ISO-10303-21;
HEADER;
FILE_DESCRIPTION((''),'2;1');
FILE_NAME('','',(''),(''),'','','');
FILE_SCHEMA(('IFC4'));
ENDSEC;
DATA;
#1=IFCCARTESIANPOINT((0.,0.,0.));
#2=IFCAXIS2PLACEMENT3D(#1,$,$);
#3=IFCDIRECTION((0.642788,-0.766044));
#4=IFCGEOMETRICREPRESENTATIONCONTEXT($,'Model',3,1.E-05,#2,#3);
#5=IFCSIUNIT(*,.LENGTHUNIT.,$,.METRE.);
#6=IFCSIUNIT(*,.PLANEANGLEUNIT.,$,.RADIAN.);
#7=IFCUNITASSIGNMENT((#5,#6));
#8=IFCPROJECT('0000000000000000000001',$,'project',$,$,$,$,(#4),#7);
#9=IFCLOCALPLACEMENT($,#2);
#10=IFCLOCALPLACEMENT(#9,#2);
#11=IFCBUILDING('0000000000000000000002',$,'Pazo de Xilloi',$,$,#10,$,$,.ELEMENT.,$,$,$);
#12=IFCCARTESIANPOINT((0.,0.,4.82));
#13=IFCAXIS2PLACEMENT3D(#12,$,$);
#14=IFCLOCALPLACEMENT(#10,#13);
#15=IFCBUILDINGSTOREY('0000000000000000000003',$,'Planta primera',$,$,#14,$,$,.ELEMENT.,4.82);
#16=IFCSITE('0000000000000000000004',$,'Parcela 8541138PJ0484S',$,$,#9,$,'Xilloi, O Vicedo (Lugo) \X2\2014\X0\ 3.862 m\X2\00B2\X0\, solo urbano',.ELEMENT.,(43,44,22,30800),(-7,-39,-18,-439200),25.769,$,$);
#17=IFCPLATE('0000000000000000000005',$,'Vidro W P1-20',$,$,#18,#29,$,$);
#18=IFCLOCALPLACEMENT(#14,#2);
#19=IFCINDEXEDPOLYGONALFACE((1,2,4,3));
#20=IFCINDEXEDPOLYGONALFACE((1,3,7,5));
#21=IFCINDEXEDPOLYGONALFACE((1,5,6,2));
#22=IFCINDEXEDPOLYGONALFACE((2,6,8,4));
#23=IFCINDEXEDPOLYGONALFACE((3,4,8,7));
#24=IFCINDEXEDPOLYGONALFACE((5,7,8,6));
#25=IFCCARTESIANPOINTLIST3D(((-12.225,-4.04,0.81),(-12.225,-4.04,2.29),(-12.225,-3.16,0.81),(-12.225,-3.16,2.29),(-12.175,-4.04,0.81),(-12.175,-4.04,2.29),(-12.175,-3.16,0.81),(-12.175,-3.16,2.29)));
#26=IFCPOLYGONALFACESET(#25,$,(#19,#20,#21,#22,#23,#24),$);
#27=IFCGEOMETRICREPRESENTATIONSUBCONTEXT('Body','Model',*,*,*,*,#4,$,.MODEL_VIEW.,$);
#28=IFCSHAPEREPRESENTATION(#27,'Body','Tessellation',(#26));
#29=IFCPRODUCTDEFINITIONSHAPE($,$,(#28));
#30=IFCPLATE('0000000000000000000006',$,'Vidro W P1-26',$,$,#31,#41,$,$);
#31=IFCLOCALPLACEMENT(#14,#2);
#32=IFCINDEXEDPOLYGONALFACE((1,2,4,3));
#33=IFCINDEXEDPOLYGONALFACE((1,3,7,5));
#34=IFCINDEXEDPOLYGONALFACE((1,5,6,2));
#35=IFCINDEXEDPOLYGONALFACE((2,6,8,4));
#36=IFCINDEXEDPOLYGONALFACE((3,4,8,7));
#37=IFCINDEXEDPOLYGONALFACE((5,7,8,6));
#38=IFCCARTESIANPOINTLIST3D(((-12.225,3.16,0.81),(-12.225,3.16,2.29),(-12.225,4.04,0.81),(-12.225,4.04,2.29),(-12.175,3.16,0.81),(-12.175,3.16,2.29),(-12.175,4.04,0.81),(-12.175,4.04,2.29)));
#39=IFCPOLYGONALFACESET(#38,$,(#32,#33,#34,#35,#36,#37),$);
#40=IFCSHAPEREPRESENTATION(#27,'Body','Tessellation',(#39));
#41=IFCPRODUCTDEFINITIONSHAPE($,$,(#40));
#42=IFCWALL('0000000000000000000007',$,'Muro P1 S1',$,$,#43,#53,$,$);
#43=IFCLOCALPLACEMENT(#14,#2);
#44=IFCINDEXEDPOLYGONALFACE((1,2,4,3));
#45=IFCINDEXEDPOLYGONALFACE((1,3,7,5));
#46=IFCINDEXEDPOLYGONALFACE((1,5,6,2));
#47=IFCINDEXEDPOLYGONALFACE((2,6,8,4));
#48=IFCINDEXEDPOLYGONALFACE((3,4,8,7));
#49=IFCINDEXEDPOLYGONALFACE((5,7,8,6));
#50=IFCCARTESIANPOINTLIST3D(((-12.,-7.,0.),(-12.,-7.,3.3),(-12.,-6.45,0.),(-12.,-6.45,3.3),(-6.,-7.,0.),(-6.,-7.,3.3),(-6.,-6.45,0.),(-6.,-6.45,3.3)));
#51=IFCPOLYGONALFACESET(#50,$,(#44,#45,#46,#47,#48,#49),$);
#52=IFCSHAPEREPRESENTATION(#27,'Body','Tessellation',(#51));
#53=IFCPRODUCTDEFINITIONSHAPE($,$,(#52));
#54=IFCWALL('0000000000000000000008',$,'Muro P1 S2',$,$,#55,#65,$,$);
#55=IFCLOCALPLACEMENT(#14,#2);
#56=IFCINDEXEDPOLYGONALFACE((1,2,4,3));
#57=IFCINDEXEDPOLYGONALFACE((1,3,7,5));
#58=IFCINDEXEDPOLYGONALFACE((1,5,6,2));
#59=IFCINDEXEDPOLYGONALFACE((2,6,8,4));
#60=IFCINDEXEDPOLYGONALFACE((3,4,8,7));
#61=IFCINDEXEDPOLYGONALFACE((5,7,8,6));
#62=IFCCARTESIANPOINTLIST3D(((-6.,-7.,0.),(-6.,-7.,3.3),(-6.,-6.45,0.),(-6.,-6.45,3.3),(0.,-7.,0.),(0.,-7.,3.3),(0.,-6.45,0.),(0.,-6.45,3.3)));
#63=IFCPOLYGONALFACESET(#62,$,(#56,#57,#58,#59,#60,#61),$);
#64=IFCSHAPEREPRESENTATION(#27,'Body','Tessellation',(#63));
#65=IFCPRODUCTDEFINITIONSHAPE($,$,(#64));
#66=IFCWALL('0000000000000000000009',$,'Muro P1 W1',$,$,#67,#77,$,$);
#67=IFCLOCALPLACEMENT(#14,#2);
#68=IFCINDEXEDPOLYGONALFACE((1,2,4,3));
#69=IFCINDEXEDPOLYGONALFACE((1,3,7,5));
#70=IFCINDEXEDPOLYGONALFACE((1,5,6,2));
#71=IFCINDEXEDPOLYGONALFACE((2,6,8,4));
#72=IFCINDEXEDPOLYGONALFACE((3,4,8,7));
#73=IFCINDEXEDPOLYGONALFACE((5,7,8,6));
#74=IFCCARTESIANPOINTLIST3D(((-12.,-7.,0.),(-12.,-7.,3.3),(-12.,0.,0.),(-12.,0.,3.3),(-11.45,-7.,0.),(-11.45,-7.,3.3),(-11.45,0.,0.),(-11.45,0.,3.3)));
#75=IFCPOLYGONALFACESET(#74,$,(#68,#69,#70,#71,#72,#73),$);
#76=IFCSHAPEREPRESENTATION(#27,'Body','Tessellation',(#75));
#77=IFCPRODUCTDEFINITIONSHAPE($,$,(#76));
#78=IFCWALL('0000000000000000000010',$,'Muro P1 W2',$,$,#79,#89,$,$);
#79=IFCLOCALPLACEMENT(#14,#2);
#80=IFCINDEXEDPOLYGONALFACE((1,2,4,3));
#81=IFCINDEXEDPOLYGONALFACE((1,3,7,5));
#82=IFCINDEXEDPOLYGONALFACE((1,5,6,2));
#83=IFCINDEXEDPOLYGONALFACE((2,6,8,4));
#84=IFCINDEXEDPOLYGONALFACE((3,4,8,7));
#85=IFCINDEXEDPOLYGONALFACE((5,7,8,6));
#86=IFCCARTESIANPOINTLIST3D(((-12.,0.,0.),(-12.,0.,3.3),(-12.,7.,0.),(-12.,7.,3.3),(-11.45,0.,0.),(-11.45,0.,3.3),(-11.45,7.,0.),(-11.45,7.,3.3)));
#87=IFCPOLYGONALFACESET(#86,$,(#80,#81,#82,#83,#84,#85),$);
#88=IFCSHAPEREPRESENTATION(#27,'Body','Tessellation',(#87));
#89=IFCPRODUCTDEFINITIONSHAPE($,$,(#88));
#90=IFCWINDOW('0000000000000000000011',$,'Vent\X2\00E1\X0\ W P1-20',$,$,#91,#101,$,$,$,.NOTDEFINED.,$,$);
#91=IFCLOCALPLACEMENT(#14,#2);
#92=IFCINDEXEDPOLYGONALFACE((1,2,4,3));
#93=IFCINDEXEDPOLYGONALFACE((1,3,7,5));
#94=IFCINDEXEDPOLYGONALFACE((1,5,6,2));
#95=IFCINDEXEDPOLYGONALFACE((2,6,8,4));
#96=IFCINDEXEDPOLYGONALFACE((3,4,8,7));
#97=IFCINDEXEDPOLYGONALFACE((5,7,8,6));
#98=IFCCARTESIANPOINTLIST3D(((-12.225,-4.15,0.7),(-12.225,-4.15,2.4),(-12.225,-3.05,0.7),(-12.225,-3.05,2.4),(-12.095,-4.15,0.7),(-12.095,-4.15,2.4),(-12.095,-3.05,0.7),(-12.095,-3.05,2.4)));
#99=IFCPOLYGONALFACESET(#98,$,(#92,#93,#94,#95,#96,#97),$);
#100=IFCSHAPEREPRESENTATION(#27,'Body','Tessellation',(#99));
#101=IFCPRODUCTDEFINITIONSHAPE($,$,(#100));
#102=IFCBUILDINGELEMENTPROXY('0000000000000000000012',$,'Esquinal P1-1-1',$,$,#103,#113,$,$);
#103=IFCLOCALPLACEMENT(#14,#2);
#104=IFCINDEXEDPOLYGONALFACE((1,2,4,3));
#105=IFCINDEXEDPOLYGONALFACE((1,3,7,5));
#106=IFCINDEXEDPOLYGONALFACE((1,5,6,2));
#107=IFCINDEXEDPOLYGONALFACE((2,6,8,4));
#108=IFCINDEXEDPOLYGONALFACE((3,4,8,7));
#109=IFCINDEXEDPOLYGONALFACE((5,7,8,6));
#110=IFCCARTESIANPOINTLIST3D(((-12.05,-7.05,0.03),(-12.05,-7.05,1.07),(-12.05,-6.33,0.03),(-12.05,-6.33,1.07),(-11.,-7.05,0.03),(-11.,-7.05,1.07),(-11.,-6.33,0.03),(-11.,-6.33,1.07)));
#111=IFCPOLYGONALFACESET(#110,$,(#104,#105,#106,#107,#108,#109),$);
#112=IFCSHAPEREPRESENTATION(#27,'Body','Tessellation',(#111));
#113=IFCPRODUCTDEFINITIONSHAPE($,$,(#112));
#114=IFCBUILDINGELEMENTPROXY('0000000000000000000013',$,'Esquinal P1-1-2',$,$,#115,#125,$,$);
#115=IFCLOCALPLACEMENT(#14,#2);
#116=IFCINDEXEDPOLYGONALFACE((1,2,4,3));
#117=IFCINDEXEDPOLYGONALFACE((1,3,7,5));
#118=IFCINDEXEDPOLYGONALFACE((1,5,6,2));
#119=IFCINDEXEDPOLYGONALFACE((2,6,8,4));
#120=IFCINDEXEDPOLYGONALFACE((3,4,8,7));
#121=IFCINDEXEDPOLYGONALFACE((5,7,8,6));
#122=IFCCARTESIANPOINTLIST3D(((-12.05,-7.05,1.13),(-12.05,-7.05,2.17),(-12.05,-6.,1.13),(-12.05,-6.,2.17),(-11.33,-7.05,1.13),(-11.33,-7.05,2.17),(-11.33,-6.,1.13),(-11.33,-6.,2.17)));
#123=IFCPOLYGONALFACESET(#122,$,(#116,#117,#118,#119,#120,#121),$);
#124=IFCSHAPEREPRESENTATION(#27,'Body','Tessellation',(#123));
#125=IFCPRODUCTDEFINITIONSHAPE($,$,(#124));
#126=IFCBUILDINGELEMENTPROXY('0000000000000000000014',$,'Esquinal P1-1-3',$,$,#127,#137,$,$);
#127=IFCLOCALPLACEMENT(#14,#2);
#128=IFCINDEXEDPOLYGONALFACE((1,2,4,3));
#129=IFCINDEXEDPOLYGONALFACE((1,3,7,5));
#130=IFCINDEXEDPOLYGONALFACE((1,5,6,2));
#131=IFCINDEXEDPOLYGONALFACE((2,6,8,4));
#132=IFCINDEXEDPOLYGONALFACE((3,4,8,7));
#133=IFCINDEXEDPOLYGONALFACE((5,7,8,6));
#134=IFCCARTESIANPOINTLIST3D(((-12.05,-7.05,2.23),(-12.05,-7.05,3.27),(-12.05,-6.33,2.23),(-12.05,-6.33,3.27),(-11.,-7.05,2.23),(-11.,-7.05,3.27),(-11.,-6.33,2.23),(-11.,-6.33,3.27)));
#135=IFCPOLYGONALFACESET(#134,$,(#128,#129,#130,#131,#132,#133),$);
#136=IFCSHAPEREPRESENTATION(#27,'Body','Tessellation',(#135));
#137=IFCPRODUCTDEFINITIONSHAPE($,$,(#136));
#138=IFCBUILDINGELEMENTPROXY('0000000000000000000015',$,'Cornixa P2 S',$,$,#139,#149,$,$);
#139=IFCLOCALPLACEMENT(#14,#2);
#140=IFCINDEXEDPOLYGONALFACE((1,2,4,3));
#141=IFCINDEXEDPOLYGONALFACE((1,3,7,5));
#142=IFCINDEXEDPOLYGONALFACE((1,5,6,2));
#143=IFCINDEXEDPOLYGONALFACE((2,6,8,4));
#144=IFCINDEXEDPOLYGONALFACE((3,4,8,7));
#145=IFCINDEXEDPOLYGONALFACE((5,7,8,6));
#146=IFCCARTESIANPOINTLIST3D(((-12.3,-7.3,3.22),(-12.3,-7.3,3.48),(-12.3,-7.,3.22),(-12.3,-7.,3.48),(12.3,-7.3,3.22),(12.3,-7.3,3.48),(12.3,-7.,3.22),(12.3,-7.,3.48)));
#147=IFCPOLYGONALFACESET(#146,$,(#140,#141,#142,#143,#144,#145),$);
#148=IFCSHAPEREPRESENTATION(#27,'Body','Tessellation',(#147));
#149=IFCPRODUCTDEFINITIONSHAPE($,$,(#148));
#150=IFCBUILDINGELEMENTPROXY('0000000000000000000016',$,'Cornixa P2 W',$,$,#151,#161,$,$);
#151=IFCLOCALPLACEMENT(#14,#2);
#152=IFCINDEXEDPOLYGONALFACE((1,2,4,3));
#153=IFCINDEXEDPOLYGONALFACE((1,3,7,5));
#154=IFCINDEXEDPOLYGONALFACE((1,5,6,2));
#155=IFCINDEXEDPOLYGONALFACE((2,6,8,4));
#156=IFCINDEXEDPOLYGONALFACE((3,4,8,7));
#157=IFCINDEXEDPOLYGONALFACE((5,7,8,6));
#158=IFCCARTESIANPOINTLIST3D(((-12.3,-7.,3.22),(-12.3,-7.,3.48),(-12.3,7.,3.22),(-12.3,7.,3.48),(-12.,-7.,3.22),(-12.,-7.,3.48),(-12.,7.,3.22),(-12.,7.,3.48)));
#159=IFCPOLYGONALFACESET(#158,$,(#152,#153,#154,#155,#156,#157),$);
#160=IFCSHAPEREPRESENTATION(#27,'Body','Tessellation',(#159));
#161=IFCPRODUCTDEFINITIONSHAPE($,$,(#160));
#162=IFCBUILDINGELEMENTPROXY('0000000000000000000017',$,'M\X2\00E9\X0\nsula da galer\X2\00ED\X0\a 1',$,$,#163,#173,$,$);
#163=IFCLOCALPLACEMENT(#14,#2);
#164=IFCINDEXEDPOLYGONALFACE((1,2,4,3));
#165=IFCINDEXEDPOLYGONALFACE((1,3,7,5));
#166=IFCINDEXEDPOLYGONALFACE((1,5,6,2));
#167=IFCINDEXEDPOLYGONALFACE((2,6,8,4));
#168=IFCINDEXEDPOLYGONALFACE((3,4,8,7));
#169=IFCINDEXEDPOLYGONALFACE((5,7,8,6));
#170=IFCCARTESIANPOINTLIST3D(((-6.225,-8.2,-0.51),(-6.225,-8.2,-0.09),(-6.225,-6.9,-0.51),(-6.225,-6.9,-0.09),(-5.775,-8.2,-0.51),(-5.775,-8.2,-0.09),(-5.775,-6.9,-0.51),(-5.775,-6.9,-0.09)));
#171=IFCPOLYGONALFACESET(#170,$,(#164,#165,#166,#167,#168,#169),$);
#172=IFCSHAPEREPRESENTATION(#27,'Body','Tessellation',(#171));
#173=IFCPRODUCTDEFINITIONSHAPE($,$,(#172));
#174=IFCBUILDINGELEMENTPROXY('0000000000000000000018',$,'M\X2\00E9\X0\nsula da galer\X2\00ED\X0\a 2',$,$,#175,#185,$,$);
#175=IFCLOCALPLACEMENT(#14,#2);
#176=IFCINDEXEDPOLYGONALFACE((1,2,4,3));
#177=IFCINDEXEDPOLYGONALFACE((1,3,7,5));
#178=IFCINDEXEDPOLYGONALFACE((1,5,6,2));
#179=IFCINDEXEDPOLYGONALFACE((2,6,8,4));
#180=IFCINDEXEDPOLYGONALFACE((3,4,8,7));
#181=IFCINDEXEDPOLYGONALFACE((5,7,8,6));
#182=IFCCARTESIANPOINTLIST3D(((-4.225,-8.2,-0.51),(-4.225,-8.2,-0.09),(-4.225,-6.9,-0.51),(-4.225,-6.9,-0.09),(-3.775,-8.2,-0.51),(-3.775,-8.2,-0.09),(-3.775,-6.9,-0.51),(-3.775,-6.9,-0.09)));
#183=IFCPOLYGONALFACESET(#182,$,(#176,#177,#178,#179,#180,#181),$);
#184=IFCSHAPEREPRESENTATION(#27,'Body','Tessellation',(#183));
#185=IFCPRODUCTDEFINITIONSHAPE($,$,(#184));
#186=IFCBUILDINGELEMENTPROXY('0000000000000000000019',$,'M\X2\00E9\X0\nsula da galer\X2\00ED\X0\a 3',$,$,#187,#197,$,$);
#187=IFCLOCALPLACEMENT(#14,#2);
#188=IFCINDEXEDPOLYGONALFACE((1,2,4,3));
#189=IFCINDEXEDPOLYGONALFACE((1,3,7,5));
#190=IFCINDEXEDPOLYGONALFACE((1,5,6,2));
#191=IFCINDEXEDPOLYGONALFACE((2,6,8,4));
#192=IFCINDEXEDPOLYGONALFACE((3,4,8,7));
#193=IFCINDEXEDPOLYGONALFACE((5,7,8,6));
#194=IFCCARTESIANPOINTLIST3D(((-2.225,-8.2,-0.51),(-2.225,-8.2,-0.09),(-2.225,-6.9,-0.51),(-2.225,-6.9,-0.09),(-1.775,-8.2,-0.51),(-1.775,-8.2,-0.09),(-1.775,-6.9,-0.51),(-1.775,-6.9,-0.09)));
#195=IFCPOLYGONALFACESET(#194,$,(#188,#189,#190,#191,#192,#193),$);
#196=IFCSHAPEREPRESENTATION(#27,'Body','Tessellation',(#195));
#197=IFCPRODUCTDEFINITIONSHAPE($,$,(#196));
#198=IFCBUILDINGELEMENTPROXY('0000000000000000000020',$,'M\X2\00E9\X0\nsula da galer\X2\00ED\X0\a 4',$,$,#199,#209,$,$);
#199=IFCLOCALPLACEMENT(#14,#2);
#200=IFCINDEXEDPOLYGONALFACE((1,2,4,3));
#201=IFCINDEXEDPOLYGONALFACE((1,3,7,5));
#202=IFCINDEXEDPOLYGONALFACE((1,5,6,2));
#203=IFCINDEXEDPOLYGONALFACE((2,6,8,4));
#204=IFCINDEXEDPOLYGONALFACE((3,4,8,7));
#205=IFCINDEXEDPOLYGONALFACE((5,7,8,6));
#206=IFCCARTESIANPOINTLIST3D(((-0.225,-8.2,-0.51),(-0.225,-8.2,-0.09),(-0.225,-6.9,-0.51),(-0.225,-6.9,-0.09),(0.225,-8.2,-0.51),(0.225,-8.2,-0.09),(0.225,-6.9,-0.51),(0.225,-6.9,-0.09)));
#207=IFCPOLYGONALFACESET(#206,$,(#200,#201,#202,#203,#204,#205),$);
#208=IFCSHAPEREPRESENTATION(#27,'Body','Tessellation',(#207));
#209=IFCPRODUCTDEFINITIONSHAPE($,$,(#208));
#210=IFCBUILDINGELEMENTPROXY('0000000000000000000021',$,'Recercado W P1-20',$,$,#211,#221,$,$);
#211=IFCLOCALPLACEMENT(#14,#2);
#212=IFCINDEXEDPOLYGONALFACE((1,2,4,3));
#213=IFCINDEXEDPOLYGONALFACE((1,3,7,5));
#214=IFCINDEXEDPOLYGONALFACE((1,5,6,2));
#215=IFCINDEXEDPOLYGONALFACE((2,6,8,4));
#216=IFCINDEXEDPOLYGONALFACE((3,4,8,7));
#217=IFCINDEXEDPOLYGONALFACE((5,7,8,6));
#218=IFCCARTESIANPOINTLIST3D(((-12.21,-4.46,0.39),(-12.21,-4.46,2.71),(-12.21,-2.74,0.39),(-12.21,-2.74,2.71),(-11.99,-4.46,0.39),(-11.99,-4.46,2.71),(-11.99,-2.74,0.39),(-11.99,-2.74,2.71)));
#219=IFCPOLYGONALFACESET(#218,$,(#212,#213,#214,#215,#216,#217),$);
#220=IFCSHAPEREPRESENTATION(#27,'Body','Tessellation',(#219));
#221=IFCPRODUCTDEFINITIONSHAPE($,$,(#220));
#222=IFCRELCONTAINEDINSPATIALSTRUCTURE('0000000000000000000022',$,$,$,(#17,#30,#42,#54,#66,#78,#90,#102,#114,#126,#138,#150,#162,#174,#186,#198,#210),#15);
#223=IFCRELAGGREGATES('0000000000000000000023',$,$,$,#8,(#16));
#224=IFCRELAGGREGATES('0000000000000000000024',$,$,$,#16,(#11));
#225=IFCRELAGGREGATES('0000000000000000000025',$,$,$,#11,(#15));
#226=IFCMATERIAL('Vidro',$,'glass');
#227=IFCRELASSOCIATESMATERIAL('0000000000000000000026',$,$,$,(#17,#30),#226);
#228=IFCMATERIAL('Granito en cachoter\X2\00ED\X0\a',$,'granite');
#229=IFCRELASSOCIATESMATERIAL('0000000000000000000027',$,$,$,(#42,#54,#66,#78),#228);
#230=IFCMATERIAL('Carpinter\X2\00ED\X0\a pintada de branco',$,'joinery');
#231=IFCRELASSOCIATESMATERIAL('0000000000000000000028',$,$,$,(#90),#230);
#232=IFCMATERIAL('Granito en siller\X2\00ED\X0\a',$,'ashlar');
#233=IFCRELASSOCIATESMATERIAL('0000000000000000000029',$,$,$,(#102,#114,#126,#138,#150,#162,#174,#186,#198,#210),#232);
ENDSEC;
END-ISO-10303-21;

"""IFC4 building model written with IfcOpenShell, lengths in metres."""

from ifc_helpers import new_model, si_unit, direction, frame, origin, origin_2d, place, context, subcontext, project, spatial, rectangle, extrude, material, element, save


model = new_model("IFC4")

# Units and contexts
model_context = context("Model", 3, precision=1e-05, world=origin(), true_north=direction((0.642788, -0.766044)))
body_context = subcontext(model_context, "Body", "Model", "MODEL_VIEW")
ifc_project = project(units=[si_unit("LENGTHUNIT", "METRE"), si_unit("PLANEANGLEUNIT", "RADIAN")], contexts=[model_context])

# Site, building, storey
site_placement = place(None, origin())
site = spatial("IfcSite", under=ifc_project, at=site_placement, Name="Parcela 8541138PJ0484S", LongName="Xilloi, O Vicedo (Lugo) — 3.862 m², solo urbano", CompositionType="ELEMENT", RefLatitude=(43, 44, 22, 30800), RefLongitude=(-7, -39, -18, -439200), RefElevation=25.769)
building_placement = place(site_placement, origin())
building = spatial("IfcBuilding", under=site, at=building_placement, Name="Pazo de Xilloi", CompositionType="ELEMENT")
storey_placement = place(building_placement, frame((0.0, 0.0, 4.82)))
storey = spatial("IfcBuildingStorey", under=building, at=storey_placement, Name="Planta primera", CompositionType="ELEMENT", Elevation=4.82)

# Shared definitions
ifc_material_1 = material(Name="Carpintería pintada de branco", Category="joinery")

# Plates
ifc_material_2 = material(Name="Vidro", Category="glass")
for number, where, name in (
    (1, (-12.2, -3.6, 1.55), "Vidro W P1-20"),
    (2, (-12.2, 3.6, 1.55), "Vidro W P1-26"),
):
    element("IfcPlate", number, at=place(storey_placement, frame(where)), inside=storey, material=ifc_material_2, Name=name, context=body_context, shape_type="SweptSolid", body=[
        extrude(rectangle(XDim=0.05, YDim=0.88, at=origin_2d()), frame((0.0, 0.0, -0.74)), (0.0, 0.0, 1.0), 1.48),
    ])

# Walls
ifc_material_3 = material(Name="Granito en cachotería", Category="granite")
for number, where, name in (
    (3, (-9.0, -6.725, 1.65), "Muro P1 S1"),
    (4, (-3.0, -6.725, 1.65), "Muro P1 S2"),
):
    element("IfcWall", number, at=place(storey_placement, frame(where)), inside=storey, material=ifc_material_3, Name=name, context=body_context, shape_type="SweptSolid", body=[
        extrude(rectangle(XDim=6.0, YDim=0.55, at=origin_2d()), frame((0.0, 0.0, -1.65)), (0.0, 0.0, 1.0), 3.3),
    ])
for number, where, name in (
    (5, (-11.725, -3.5, 1.65), "Muro P1 W1"),
    (6, (-11.725, 3.5, 1.65), "Muro P1 W2"),
):
    element("IfcWall", number, at=place(storey_placement, frame(where)), inside=storey, material=ifc_material_3, Name=name, context=body_context, shape_type="SweptSolid", body=[
        extrude(rectangle(XDim=0.55, YDim=7.0, at=origin_2d()), frame((0.0, 0.0, -1.65)), (0.0, 0.0, 1.0), 3.3),
    ])

# Window
window_placement = place(storey_placement, frame((-12.16, -3.6, 1.55)))
element("IfcWindow", 7, at=window_placement, inside=storey, material=ifc_material_1, Name="Ventá W P1-20", PredefinedType="NOTDEFINED", context=body_context, shape_type="SweptSolid", body=[
    extrude(rectangle(XDim=0.13, YDim=1.1, at=origin_2d()), frame((0.0, 0.0, -0.85)), (0.0, 0.0, 1.0), 1.7),
])

# Building element proxies
ifc_material_4 = material(Name="Granito en sillería", Category="ashlar")
proxy_1_placement = place(storey_placement, frame((-11.525, -6.69, 0.55)))
element("IfcBuildingElementProxy", 8, at=proxy_1_placement, inside=storey, material=ifc_material_4, Name="Esquinal P1-1-1", context=body_context, shape_type="SweptSolid", body=[
    extrude(rectangle(XDim=1.05, YDim=0.72, at=origin_2d()), frame((0.0, 0.0, -0.52)), (0.0, 0.0, 1.0), 1.04),
])
proxy_2_placement = place(storey_placement, frame((-11.69, -6.525, 1.65)))
element("IfcBuildingElementProxy", 9, at=proxy_2_placement, inside=storey, material=ifc_material_4, Name="Esquinal P1-1-2", context=body_context, shape_type="SweptSolid", body=[
    extrude(rectangle(XDim=0.72, YDim=1.05, at=origin_2d()), frame((0.0, 0.0, -0.52)), (0.0, 0.0, 1.0), 1.04),
])
proxy_3_placement = place(storey_placement, frame((-11.525, -6.69, 2.75)))
element("IfcBuildingElementProxy", 10, at=proxy_3_placement, inside=storey, material=ifc_material_4, Name="Esquinal P1-1-3", context=body_context, shape_type="SweptSolid", body=[
    extrude(rectangle(XDim=1.05, YDim=0.72, at=origin_2d()), frame((0.0, 0.0, -0.52)), (0.0, 0.0, 1.0), 1.04),
])
proxy_4_placement = place(storey_placement, frame((0.0, -7.15, 3.35)))
element("IfcBuildingElementProxy", 11, at=proxy_4_placement, inside=storey, material=ifc_material_4, Name="Cornixa P2 S", context=body_context, shape_type="SweptSolid", body=[
    extrude(rectangle(XDim=24.6, YDim=0.3, at=origin_2d()), frame((0.0, 0.0, -0.13)), (0.0, 0.0, 1.0), 0.26),
])
proxy_5_placement = place(storey_placement, frame((-12.15, 0.0, 3.35)))
element("IfcBuildingElementProxy", 12, at=proxy_5_placement, inside=storey, material=ifc_material_4, Name="Cornixa P2 W", context=body_context, shape_type="SweptSolid", body=[
    extrude(rectangle(XDim=0.3, YDim=14.0, at=origin_2d()), frame((0.0, 0.0, -0.13)), (0.0, 0.0, 1.0), 0.26),
])
for number, where, name in (
    (13, (-6.0, -7.55, -0.3), "Ménsula da galería 1"),
    (14, (-4.0, -7.55, -0.3), "Ménsula da galería 2"),
    (15, (-2.0, -7.55, -0.3), "Ménsula da galería 3"),
    (16, (0.0, -7.55, -0.3), "Ménsula da galería 4"),
):
    element("IfcBuildingElementProxy", number, at=place(storey_placement, frame(where)), inside=storey, material=ifc_material_4, Name=name, context=body_context, shape_type="SweptSolid", body=[
        extrude(rectangle(XDim=0.45, YDim=1.3, at=origin_2d()), frame((0.0, 0.0, -0.21)), (0.0, 0.0, 1.0), 0.42),
    ])
proxy_6_placement = place(storey_placement, frame((-12.1, -3.6, 1.55)))
element("IfcBuildingElementProxy", 17, at=proxy_6_placement, inside=storey, material=ifc_material_4, Name="Recercado W P1-20", context=body_context, shape_type="SweptSolid", body=[
    extrude(rectangle(XDim=0.22, YDim=1.72, at=origin_2d()), frame((0.0, 0.0, -1.16)), (0.0, 0.0, 1.0), 2.32),
])

save(model, "model.ifc")
